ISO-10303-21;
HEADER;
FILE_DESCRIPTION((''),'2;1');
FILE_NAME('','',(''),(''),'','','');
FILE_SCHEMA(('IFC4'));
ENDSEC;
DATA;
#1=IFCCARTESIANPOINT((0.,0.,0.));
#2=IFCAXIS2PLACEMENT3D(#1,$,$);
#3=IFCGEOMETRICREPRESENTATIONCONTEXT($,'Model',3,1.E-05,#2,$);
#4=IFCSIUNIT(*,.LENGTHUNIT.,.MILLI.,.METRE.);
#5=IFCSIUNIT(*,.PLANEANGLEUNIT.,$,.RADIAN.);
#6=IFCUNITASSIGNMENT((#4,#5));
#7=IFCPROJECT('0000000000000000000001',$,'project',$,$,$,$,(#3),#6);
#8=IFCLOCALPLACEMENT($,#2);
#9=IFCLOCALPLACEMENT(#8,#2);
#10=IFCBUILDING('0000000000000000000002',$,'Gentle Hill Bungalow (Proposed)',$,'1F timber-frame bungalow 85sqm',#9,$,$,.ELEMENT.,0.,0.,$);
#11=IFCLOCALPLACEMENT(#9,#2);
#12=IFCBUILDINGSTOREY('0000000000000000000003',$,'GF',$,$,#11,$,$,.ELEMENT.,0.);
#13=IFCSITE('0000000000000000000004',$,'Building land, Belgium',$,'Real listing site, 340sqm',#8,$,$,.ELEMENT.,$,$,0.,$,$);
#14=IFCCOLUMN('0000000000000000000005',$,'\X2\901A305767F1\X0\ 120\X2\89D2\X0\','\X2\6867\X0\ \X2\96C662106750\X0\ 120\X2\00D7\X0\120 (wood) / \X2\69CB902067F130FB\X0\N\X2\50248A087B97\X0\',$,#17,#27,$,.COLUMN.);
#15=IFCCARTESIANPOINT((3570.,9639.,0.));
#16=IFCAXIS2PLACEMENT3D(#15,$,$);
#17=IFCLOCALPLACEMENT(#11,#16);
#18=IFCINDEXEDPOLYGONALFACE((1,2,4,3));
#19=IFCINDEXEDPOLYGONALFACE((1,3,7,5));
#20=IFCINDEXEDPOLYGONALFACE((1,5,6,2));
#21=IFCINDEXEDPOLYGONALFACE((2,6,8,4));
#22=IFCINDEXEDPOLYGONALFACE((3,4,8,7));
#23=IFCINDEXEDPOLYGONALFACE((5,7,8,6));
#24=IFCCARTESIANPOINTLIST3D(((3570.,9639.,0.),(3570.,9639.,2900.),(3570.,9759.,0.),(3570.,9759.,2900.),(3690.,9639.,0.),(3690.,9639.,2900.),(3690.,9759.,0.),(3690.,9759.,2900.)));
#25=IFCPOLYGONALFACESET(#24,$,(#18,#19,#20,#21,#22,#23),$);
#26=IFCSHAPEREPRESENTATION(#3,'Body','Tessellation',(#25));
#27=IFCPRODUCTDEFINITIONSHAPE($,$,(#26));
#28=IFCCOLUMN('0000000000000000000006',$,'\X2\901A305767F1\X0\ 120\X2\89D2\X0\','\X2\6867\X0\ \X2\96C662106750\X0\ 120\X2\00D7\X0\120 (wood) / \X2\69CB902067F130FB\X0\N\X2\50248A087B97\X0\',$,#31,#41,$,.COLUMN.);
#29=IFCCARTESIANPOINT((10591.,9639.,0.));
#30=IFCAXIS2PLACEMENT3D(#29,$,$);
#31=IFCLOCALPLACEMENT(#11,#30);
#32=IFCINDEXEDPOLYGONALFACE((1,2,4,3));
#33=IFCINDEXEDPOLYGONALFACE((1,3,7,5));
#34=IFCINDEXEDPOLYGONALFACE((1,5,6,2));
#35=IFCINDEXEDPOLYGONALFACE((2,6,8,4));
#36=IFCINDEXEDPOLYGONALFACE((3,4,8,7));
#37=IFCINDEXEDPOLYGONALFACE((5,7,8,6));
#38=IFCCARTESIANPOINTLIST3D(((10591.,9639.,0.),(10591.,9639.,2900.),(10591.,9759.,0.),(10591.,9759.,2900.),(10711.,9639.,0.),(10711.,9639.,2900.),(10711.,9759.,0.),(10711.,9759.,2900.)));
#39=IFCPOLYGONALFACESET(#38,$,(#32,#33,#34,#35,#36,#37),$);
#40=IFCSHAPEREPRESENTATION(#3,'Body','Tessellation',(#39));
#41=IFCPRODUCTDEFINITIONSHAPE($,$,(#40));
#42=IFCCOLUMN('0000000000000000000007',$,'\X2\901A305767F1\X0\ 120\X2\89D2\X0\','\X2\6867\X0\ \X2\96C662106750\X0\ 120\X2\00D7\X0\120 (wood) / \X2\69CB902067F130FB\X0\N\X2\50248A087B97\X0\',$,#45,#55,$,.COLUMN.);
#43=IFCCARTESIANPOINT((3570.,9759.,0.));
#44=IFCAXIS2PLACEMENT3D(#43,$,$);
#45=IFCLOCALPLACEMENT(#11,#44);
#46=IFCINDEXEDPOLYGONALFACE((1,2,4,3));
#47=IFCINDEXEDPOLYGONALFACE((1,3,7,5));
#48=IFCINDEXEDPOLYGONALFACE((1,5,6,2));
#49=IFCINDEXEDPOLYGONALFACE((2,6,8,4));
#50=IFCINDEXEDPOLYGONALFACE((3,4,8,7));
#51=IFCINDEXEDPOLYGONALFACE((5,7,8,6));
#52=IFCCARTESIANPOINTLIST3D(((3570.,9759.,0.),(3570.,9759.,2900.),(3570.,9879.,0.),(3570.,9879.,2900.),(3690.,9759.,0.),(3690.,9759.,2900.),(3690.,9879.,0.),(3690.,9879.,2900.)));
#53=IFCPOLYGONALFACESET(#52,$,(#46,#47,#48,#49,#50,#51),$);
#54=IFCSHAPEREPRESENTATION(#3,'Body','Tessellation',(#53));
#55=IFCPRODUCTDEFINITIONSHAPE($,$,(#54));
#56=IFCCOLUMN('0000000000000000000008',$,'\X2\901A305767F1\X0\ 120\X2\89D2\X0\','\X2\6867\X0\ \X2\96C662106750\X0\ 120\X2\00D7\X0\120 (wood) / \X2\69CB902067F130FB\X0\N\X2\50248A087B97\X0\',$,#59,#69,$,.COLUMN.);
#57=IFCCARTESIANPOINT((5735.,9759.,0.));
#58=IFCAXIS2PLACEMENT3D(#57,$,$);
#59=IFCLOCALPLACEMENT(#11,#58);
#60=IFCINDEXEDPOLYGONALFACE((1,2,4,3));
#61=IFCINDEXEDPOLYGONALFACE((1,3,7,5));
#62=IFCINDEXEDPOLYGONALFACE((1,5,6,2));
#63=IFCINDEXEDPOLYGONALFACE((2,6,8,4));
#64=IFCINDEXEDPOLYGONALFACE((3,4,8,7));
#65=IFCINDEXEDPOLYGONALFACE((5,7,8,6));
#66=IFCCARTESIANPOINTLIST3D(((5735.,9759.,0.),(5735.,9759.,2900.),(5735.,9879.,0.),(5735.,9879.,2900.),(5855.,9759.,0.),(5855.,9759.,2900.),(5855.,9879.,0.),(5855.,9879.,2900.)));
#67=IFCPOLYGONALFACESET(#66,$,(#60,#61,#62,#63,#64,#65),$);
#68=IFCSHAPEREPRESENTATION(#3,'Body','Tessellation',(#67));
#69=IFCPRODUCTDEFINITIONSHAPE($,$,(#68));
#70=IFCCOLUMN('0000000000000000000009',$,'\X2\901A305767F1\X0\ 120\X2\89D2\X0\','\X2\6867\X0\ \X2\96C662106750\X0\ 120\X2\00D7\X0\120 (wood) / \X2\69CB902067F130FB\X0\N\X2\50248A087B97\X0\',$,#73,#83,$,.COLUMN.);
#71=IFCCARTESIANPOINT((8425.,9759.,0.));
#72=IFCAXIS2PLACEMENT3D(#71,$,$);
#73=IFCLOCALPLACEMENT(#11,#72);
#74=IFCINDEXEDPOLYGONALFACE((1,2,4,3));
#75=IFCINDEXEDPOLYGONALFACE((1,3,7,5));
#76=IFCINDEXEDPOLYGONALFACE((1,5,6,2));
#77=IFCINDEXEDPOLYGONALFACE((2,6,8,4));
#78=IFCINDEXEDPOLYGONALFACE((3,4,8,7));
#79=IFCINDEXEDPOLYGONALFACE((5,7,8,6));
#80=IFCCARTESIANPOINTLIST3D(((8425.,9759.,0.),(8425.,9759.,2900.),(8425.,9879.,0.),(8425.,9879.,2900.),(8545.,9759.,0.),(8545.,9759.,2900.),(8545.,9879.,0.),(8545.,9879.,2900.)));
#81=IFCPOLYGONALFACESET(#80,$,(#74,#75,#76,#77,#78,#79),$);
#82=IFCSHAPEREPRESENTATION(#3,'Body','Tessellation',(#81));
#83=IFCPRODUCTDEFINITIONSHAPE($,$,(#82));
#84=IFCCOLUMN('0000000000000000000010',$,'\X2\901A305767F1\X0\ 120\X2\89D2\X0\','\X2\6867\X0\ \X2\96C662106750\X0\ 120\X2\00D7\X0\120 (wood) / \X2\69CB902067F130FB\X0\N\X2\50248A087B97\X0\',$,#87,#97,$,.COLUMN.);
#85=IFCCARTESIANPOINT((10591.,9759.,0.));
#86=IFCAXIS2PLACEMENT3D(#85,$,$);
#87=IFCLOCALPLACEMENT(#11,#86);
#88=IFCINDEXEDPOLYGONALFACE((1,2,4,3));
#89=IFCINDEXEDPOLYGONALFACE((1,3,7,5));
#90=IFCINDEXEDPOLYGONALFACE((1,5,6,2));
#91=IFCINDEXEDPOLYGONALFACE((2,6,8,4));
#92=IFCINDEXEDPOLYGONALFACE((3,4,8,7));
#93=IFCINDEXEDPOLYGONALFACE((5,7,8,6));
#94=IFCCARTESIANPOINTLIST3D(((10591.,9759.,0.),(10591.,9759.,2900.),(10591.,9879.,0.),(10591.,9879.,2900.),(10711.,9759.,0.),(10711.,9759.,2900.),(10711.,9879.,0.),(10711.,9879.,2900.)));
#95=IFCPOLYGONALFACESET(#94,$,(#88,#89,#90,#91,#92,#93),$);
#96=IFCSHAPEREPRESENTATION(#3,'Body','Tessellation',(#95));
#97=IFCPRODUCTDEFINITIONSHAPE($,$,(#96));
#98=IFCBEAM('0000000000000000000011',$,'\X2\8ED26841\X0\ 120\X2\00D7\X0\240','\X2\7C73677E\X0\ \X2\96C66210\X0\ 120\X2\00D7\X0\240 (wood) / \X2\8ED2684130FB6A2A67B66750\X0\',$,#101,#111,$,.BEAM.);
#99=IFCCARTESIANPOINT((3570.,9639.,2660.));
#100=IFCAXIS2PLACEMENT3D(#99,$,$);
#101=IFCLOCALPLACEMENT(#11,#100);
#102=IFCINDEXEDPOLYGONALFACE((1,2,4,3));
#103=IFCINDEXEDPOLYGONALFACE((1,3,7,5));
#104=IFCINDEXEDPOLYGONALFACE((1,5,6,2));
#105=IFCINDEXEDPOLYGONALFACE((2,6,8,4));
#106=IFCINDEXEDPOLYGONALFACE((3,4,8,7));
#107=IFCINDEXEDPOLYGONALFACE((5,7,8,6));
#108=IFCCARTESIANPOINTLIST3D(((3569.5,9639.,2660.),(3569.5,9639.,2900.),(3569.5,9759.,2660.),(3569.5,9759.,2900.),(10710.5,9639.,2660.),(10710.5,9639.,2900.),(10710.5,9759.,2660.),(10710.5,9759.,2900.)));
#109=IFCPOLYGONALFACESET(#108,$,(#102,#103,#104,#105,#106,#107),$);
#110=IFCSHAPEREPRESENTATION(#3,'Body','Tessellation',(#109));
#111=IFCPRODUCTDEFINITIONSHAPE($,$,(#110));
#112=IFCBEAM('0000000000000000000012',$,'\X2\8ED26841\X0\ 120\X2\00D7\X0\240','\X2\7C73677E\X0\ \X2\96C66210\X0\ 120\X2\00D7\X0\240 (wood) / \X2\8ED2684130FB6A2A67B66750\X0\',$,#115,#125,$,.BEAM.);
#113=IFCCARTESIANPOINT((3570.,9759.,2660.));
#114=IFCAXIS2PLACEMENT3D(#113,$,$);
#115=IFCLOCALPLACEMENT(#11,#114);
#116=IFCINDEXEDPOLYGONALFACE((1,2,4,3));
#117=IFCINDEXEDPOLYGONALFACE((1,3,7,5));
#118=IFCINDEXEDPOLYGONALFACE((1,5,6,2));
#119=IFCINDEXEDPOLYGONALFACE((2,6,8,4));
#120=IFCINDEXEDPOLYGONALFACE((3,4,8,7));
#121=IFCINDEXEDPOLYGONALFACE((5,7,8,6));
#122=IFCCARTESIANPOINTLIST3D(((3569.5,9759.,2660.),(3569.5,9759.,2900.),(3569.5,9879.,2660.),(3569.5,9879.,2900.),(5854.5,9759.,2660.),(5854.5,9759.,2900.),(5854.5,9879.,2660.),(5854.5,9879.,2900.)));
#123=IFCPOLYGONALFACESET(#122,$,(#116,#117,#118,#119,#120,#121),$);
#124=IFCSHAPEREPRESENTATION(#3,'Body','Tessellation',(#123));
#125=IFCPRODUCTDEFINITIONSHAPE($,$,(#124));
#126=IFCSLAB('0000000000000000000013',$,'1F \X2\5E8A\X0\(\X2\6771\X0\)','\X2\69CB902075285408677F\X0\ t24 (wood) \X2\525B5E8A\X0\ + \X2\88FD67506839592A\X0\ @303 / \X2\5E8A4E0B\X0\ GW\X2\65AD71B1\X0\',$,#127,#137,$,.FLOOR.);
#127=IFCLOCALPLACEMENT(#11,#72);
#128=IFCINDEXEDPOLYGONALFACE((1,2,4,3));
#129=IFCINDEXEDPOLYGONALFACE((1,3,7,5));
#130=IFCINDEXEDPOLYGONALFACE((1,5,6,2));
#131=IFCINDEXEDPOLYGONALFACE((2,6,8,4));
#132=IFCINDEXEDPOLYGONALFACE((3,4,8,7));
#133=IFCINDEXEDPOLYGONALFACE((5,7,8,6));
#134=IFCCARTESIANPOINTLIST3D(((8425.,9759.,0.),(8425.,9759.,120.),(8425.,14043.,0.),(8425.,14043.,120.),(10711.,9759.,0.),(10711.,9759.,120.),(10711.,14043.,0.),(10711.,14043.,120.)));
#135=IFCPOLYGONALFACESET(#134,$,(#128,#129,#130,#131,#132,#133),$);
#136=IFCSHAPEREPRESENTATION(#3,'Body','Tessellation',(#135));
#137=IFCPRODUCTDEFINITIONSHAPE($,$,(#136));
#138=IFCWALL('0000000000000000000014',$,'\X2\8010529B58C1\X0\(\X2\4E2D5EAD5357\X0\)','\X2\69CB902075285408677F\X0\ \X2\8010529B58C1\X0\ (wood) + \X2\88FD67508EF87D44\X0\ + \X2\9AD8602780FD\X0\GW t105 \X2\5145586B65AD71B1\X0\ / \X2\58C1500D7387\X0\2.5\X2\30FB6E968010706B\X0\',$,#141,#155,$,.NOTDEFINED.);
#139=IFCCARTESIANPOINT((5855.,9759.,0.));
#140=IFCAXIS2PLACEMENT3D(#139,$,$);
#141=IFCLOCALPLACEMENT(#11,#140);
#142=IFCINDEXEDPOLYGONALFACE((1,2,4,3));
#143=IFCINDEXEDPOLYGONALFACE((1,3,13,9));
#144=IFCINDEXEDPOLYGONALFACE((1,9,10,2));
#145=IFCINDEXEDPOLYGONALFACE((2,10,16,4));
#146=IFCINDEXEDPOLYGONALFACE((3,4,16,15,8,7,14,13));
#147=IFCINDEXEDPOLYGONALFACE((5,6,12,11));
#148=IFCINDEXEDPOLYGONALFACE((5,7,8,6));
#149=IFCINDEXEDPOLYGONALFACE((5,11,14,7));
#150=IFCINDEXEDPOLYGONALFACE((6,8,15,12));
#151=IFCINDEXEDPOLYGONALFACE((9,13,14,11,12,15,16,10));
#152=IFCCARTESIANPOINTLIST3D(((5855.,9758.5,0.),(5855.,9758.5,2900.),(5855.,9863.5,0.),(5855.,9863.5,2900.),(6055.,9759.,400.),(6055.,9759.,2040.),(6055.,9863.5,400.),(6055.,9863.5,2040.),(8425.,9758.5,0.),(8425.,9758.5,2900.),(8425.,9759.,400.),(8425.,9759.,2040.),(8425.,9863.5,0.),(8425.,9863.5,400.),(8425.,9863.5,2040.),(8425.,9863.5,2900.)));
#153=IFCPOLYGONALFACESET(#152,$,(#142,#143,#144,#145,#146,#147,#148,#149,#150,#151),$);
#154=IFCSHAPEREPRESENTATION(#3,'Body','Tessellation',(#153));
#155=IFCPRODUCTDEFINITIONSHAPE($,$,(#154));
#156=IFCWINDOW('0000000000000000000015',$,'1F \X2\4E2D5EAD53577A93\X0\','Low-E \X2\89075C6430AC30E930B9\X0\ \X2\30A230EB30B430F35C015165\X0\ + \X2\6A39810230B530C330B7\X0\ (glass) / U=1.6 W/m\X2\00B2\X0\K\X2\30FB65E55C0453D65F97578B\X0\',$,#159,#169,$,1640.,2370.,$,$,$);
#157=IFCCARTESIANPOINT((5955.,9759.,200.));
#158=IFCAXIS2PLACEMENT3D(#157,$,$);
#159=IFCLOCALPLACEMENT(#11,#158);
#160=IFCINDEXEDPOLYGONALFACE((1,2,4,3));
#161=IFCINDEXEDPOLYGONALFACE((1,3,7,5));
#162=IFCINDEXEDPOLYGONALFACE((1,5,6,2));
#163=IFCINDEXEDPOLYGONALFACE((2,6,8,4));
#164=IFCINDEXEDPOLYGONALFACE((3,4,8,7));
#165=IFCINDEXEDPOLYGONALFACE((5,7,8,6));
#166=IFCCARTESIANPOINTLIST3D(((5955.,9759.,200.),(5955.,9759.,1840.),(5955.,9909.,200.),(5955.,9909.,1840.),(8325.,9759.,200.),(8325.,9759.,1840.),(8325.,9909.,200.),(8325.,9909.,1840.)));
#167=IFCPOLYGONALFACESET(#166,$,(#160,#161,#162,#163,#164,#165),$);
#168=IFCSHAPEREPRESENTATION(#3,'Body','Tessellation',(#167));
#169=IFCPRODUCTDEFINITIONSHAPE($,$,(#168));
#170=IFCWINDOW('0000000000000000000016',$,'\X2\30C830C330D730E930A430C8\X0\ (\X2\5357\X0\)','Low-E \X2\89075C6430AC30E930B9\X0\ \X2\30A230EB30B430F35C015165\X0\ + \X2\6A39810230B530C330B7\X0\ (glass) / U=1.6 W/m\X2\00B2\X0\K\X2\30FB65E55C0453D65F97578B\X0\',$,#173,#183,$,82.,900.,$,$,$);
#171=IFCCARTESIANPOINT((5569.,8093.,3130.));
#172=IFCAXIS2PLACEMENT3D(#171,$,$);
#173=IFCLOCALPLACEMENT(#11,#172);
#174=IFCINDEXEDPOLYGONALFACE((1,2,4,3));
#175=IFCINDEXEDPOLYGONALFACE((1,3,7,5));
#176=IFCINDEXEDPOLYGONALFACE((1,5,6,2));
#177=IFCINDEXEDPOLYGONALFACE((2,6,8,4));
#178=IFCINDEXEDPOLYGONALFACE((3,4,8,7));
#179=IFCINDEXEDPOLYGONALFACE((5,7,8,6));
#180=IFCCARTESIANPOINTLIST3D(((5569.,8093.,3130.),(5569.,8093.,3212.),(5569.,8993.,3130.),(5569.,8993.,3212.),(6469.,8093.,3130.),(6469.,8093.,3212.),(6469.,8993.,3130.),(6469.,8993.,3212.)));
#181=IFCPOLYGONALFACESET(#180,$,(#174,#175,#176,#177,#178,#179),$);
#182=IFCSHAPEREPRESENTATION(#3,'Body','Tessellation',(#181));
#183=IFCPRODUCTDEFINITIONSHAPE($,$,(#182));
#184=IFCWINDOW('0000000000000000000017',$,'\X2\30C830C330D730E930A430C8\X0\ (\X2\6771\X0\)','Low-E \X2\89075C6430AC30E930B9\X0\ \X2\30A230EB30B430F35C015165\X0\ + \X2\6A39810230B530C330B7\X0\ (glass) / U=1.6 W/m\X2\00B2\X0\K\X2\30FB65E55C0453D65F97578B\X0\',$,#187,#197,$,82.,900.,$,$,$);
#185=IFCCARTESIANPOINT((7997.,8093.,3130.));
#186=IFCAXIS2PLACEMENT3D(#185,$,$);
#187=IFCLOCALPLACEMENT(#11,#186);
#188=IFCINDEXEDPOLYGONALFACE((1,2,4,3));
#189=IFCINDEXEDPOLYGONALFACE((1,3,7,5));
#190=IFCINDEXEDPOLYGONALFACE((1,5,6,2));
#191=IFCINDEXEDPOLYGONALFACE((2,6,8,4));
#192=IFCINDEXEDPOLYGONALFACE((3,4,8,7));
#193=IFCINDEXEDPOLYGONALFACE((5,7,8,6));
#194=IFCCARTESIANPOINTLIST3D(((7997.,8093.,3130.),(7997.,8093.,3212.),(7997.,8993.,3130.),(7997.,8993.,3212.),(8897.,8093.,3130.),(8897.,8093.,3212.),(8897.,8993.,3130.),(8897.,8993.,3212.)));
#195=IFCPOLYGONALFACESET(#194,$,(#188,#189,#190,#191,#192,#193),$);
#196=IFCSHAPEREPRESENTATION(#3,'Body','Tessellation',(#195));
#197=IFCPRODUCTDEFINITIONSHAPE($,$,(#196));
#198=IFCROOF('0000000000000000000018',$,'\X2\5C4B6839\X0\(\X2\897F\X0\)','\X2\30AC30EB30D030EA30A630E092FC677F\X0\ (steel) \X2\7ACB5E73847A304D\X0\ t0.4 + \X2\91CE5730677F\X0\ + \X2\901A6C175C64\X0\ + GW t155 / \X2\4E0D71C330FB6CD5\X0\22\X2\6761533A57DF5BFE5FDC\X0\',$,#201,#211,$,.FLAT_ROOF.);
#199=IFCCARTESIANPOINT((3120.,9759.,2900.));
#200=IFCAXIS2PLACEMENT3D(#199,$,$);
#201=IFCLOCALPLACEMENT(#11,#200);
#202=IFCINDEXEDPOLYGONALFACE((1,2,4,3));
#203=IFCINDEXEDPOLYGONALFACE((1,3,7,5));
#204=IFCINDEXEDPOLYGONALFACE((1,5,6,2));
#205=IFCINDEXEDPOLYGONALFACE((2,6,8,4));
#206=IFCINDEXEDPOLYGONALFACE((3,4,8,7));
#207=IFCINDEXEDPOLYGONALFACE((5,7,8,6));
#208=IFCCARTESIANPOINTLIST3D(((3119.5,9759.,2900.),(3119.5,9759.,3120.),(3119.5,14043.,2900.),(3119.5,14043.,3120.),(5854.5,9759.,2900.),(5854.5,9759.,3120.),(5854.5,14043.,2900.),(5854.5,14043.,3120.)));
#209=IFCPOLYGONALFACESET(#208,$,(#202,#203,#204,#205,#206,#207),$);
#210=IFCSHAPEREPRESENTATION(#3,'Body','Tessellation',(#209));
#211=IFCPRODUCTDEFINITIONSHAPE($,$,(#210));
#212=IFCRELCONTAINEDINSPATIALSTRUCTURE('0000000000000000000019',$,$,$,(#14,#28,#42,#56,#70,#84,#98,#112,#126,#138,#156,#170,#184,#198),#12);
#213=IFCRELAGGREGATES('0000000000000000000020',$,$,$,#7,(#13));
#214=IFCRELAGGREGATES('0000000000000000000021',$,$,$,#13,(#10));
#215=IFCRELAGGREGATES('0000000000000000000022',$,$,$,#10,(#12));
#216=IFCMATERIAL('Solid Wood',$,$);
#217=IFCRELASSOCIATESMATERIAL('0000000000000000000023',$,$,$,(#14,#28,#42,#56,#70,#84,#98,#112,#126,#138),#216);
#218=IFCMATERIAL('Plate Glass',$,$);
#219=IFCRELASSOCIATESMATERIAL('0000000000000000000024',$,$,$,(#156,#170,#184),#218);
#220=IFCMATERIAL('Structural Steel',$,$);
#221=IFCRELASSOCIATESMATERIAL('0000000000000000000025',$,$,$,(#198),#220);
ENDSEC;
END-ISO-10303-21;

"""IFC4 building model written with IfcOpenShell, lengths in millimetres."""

from ifc_helpers import new_model, si_unit, frame, frame_2d, origin, place, context, project, spatial, rectangle, extrude, material, element, fill, save


model = new_model("IFC4")

# Units and contexts
model_context = context("Model", 3, precision=1e-05, world=origin())
ifc_project = project(units=[si_unit("LENGTHUNIT", "METRE", prefix="MILLI"), si_unit("PLANEANGLEUNIT", "RADIAN")], contexts=[model_context])

# Site, building, storey
site_placement = place(None, origin())
site = spatial("IfcSite", under=ifc_project, at=site_placement, Name="Building land, Belgium", ObjectType="Real listing site, 340sqm", CompositionType="ELEMENT", RefElevation=0.0)
building_placement = place(site_placement, origin())
building = spatial("IfcBuilding", under=site, at=building_placement, Name="Gentle Hill Bungalow (Proposed)", ObjectType="1F timber-frame bungalow 85sqm", CompositionType="ELEMENT", ElevationOfRefHeight=0.0, ElevationOfTerrain=0.0)
storey_placement = place(building_placement, origin())
storey = spatial("IfcBuildingStorey", under=building, at=storey_placement, Name="GF", CompositionType="ELEMENT", Elevation=0.0)

# Columns
ifc_material_1 = material(Name="Solid Wood")
column_1_placement = place(storey_placement, frame((3570.0, 9639.0, 0.0)))
element("IfcColumn", 1, at=column_1_placement, inside=storey, material=ifc_material_1, Name="通し柱 120角", Description="桧 集成材 120×120 (wood) / 構造柱・N値計算", PredefinedType="COLUMN", context=model_context, shape_type="SweptSolid", body=[
    extrude(rectangle(XDim=120.0, YDim=120.0, at=frame_2d((60.0, 60.0))), frame((3570.0, 9639.0, 0.0)), (0.0, 0.0, 1.0), 2900.0),
])
column_2_placement = place(storey_placement, frame((10591.0, 9639.0, 0.0)))
element("IfcColumn", 2, at=column_2_placement, inside=storey, material=ifc_material_1, Name="通し柱 120角", Description="桧 集成材 120×120 (wood) / 構造柱・N値計算", PredefinedType="COLUMN", context=model_context, shape_type="SweptSolid", body=[
    extrude(rectangle(XDim=120.0, YDim=120.0, at=frame_2d((60.0, 60.0))), frame((10591.0, 9639.0, 0.0)), (0.0, 0.0, 1.0), 2900.0),
])
column_3_placement = place(storey_placement, frame((3570.0, 9759.0, 0.0)))
element("IfcColumn", 3, at=column_3_placement, inside=storey, material=ifc_material_1, Name="通し柱 120角", Description="桧 集成材 120×120 (wood) / 構造柱・N値計算", PredefinedType="COLUMN", context=model_context, shape_type="SweptSolid", body=[
    extrude(rectangle(XDim=120.0, YDim=120.0, at=frame_2d((60.0, 60.0))), frame((3570.0, 9759.0, 0.0)), (0.0, 0.0, 1.0), 2900.0),
])
column_4_placement = place(storey_placement, frame((5735.0, 9759.0, 0.0)))
element("IfcColumn", 4, at=column_4_placement, inside=storey, material=ifc_material_1, Name="通し柱 120角", Description="桧 集成材 120×120 (wood) / 構造柱・N値計算", PredefinedType="COLUMN", context=model_context, shape_type="SweptSolid", body=[
    extrude(rectangle(XDim=120.0, YDim=120.0, at=frame_2d((60.0, 60.0))), frame((5735.0, 9759.0, 0.0)), (0.0, 0.0, 1.0), 2900.0),
])
column_5_placement = place(storey_placement, frame((8425.0, 9759.0, 0.0)))
element("IfcColumn", 5, at=column_5_placement, inside=storey, material=ifc_material_1, Name="通し柱 120角", Description="桧 集成材 120×120 (wood) / 構造柱・N値計算", PredefinedType="COLUMN", context=model_context, shape_type="SweptSolid", body=[
    extrude(rectangle(XDim=120.0, YDim=120.0, at=frame_2d((60.0, 60.0))), frame((8425.0, 9759.0, 0.0)), (0.0, 0.0, 1.0), 2900.0),
])
column_6_placement = place(storey_placement, frame((10591.0, 9759.0, 0.0)))
element("IfcColumn", 6, at=column_6_placement, inside=storey, material=ifc_material_1, Name="通し柱 120角", Description="桧 集成材 120×120 (wood) / 構造柱・N値計算", PredefinedType="COLUMN", context=model_context, shape_type="SweptSolid", body=[
    extrude(rectangle(XDim=120.0, YDim=120.0, at=frame_2d((60.0, 60.0))), frame((10591.0, 9759.0, 0.0)), (0.0, 0.0, 1.0), 2900.0),
])

# Beams
beam_1_placement = place(storey_placement, frame((3570.0, 9639.0, 2660.0)))
element("IfcBeam", 7, at=beam_1_placement, inside=storey, material=ifc_material_1, Name="軒桁 120×240", Description="米松 集成 120×240 (wood) / 軒桁・横架材", PredefinedType="BEAM", context=model_context, shape_type="SweptSolid", body=[
    extrude(rectangle(XDim=7141.0, YDim=120.0, at=frame_2d((3570.0, 60.0))), frame((3570.0, 9639.0, 2660.0)), (0.0, 0.0, 1.0), 240.0),
])
beam_2_placement = place(storey_placement, frame((3570.0, 9759.0, 2660.0)))
element("IfcBeam", 8, at=beam_2_placement, inside=storey, material=ifc_material_1, Name="軒桁 120×240", Description="米松 集成 120×240 (wood) / 軒桁・横架材", PredefinedType="BEAM", context=model_context, shape_type="SweptSolid", body=[
    extrude(rectangle(XDim=2285.0, YDim=120.0, at=frame_2d((1142.0, 60.0))), frame((3570.0, 9759.0, 2660.0)), (0.0, 0.0, 1.0), 240.0),
])

# Slab
slab_1_placement = place(storey_placement, frame((8425.0, 9759.0, 0.0)))
element("IfcSlab", 9, at=slab_1_placement, inside=storey, material=ifc_material_1, Name="1F 床(東)", Description="構造用合板 t24 (wood) 剛床 + 製材根太 @303 / 床下 GW断熱", PredefinedType="FLOOR", context=model_context, shape_type="SweptSolid", body=[
    extrude(rectangle(XDim=2286.0, YDim=4284.0, at=frame_2d((1143.0, 2142.0))), frame((8425.0, 9759.0, 0.0)), (0.0, 0.0, 1.0), 120.0),
])

# Wall, opening, window
wall_1_placement = place(storey_placement, frame((5855.0, 9759.0, 0.0)))
wall_1 = element("IfcWall", 10, at=wall_1_placement, inside=storey, material=ifc_material_1, Name="耐力壁(中庭南)", Description="構造用合板 耐力壁 (wood) + 製材軸組 + 高性能GW t105 充填断熱 / 壁倍率2.5・準耐火", PredefinedType="NOTDEFINED", context=model_context, shape_type="SweptSolid", body=[
    extrude(rectangle(XDim=2570.0, YDim=105.0, at=frame_2d((1285.0, 52.0))), frame((5855.0, 9759.0, 0.0)), (0.0, 0.0, 1.0), 2900.0),
])
opening_placement = place(storey_placement, frame((5955.0, 9759.0, 200.0)))
opening = element("IfcOpeningElement", 11, at=opening_placement, cuts=wall_1, PredefinedType="NOTDEFINED", context=model_context, shape_type="SweptSolid", body=[
    extrude(rectangle(XDim=2370.0, YDim=150.0, at=frame_2d((1185.0, 75.0))), frame((5955.0, 9759.0, 200.0)), (0.0, 0.0, 1.0), 1640.0),
])
ifc_material_2 = material(Name="Plate Glass")
window_1_placement = place(storey_placement, frame((5955.0, 9759.0, 200.0)))
window_1 = element("IfcWindow", 12, at=window_1_placement, inside=storey, material=ifc_material_2, Name="1F 中庭南窓", Description="Low-E 複層ガラス アルゴン封入 + 樹脂サッシ (glass) / U=1.6 W/m²K・日射取得型", OverallHeight=1640.0, OverallWidth=2370.0, context=model_context, shape_type="SweptSolid", body=[
    extrude(rectangle(XDim=2370.0, YDim=150.0, at=frame_2d((1185.0, 75.0))), frame((5955.0, 9759.0, 200.0)), (0.0, 0.0, 1.0), 1640.0),
])
fill(opening, window_1)

# Windows
window_2_placement = place(storey_placement, frame((5569.0, 8093.0, 3130.0)))
element("IfcWindow", 13, at=window_2_placement, inside=storey, material=ifc_material_2, Name="トップライト (南)", Description="Low-E 複層ガラス アルゴン封入 + 樹脂サッシ (glass) / U=1.6 W/m²K・日射取得型", OverallHeight=82.0, OverallWidth=900.0, context=model_context, shape_type="SweptSolid", body=[
    extrude(rectangle(XDim=900.0, YDim=900.0, at=frame_2d((450.0, 450.0))), frame((5569.0, 8093.0, 3130.0)), (0.0, 0.0, 1.0), 82.0),
])
window_3_placement = place(storey_placement, frame((7997.0, 8093.0, 3130.0)))
element("IfcWindow", 14, at=window_3_placement, inside=storey, material=ifc_material_2, Name="トップライト (東)", Description="Low-E 複層ガラス アルゴン封入 + 樹脂サッシ (glass) / U=1.6 W/m²K・日射取得型", OverallHeight=82.0, OverallWidth=900.0, context=model_context, shape_type="SweptSolid", body=[
    extrude(rectangle(XDim=900.0, YDim=900.0, at=frame_2d((450.0, 450.0))), frame((7997.0, 8093.0, 3130.0)), (0.0, 0.0, 1.0), 82.0),
])

# Roof
ifc_material_3 = material(Name="Structural Steel")
roof_1_placement = place(storey_placement, frame((3120.0, 9759.0, 2900.0)))
element("IfcRoof", 15, at=roof_1_placement, inside=storey, material=ifc_material_3, Name="屋根(西)", Description="ガルバリウム鋼板 (steel) 立平葺き t0.4 + 野地板 + 通気層 + GW t155 / 不燃・法22条区域対応", PredefinedType="FLAT_ROOF", context=model_context, shape_type="SweptSolid", body=[
    extrude(rectangle(XDim=2735.0, YDim=4284.0, at=frame_2d((1367.0, 2142.0))), frame((3120.0, 9759.0, 2900.0)), (0.0, 0.0, 1.0), 220.0),
])

save(model, "model.ifc")
